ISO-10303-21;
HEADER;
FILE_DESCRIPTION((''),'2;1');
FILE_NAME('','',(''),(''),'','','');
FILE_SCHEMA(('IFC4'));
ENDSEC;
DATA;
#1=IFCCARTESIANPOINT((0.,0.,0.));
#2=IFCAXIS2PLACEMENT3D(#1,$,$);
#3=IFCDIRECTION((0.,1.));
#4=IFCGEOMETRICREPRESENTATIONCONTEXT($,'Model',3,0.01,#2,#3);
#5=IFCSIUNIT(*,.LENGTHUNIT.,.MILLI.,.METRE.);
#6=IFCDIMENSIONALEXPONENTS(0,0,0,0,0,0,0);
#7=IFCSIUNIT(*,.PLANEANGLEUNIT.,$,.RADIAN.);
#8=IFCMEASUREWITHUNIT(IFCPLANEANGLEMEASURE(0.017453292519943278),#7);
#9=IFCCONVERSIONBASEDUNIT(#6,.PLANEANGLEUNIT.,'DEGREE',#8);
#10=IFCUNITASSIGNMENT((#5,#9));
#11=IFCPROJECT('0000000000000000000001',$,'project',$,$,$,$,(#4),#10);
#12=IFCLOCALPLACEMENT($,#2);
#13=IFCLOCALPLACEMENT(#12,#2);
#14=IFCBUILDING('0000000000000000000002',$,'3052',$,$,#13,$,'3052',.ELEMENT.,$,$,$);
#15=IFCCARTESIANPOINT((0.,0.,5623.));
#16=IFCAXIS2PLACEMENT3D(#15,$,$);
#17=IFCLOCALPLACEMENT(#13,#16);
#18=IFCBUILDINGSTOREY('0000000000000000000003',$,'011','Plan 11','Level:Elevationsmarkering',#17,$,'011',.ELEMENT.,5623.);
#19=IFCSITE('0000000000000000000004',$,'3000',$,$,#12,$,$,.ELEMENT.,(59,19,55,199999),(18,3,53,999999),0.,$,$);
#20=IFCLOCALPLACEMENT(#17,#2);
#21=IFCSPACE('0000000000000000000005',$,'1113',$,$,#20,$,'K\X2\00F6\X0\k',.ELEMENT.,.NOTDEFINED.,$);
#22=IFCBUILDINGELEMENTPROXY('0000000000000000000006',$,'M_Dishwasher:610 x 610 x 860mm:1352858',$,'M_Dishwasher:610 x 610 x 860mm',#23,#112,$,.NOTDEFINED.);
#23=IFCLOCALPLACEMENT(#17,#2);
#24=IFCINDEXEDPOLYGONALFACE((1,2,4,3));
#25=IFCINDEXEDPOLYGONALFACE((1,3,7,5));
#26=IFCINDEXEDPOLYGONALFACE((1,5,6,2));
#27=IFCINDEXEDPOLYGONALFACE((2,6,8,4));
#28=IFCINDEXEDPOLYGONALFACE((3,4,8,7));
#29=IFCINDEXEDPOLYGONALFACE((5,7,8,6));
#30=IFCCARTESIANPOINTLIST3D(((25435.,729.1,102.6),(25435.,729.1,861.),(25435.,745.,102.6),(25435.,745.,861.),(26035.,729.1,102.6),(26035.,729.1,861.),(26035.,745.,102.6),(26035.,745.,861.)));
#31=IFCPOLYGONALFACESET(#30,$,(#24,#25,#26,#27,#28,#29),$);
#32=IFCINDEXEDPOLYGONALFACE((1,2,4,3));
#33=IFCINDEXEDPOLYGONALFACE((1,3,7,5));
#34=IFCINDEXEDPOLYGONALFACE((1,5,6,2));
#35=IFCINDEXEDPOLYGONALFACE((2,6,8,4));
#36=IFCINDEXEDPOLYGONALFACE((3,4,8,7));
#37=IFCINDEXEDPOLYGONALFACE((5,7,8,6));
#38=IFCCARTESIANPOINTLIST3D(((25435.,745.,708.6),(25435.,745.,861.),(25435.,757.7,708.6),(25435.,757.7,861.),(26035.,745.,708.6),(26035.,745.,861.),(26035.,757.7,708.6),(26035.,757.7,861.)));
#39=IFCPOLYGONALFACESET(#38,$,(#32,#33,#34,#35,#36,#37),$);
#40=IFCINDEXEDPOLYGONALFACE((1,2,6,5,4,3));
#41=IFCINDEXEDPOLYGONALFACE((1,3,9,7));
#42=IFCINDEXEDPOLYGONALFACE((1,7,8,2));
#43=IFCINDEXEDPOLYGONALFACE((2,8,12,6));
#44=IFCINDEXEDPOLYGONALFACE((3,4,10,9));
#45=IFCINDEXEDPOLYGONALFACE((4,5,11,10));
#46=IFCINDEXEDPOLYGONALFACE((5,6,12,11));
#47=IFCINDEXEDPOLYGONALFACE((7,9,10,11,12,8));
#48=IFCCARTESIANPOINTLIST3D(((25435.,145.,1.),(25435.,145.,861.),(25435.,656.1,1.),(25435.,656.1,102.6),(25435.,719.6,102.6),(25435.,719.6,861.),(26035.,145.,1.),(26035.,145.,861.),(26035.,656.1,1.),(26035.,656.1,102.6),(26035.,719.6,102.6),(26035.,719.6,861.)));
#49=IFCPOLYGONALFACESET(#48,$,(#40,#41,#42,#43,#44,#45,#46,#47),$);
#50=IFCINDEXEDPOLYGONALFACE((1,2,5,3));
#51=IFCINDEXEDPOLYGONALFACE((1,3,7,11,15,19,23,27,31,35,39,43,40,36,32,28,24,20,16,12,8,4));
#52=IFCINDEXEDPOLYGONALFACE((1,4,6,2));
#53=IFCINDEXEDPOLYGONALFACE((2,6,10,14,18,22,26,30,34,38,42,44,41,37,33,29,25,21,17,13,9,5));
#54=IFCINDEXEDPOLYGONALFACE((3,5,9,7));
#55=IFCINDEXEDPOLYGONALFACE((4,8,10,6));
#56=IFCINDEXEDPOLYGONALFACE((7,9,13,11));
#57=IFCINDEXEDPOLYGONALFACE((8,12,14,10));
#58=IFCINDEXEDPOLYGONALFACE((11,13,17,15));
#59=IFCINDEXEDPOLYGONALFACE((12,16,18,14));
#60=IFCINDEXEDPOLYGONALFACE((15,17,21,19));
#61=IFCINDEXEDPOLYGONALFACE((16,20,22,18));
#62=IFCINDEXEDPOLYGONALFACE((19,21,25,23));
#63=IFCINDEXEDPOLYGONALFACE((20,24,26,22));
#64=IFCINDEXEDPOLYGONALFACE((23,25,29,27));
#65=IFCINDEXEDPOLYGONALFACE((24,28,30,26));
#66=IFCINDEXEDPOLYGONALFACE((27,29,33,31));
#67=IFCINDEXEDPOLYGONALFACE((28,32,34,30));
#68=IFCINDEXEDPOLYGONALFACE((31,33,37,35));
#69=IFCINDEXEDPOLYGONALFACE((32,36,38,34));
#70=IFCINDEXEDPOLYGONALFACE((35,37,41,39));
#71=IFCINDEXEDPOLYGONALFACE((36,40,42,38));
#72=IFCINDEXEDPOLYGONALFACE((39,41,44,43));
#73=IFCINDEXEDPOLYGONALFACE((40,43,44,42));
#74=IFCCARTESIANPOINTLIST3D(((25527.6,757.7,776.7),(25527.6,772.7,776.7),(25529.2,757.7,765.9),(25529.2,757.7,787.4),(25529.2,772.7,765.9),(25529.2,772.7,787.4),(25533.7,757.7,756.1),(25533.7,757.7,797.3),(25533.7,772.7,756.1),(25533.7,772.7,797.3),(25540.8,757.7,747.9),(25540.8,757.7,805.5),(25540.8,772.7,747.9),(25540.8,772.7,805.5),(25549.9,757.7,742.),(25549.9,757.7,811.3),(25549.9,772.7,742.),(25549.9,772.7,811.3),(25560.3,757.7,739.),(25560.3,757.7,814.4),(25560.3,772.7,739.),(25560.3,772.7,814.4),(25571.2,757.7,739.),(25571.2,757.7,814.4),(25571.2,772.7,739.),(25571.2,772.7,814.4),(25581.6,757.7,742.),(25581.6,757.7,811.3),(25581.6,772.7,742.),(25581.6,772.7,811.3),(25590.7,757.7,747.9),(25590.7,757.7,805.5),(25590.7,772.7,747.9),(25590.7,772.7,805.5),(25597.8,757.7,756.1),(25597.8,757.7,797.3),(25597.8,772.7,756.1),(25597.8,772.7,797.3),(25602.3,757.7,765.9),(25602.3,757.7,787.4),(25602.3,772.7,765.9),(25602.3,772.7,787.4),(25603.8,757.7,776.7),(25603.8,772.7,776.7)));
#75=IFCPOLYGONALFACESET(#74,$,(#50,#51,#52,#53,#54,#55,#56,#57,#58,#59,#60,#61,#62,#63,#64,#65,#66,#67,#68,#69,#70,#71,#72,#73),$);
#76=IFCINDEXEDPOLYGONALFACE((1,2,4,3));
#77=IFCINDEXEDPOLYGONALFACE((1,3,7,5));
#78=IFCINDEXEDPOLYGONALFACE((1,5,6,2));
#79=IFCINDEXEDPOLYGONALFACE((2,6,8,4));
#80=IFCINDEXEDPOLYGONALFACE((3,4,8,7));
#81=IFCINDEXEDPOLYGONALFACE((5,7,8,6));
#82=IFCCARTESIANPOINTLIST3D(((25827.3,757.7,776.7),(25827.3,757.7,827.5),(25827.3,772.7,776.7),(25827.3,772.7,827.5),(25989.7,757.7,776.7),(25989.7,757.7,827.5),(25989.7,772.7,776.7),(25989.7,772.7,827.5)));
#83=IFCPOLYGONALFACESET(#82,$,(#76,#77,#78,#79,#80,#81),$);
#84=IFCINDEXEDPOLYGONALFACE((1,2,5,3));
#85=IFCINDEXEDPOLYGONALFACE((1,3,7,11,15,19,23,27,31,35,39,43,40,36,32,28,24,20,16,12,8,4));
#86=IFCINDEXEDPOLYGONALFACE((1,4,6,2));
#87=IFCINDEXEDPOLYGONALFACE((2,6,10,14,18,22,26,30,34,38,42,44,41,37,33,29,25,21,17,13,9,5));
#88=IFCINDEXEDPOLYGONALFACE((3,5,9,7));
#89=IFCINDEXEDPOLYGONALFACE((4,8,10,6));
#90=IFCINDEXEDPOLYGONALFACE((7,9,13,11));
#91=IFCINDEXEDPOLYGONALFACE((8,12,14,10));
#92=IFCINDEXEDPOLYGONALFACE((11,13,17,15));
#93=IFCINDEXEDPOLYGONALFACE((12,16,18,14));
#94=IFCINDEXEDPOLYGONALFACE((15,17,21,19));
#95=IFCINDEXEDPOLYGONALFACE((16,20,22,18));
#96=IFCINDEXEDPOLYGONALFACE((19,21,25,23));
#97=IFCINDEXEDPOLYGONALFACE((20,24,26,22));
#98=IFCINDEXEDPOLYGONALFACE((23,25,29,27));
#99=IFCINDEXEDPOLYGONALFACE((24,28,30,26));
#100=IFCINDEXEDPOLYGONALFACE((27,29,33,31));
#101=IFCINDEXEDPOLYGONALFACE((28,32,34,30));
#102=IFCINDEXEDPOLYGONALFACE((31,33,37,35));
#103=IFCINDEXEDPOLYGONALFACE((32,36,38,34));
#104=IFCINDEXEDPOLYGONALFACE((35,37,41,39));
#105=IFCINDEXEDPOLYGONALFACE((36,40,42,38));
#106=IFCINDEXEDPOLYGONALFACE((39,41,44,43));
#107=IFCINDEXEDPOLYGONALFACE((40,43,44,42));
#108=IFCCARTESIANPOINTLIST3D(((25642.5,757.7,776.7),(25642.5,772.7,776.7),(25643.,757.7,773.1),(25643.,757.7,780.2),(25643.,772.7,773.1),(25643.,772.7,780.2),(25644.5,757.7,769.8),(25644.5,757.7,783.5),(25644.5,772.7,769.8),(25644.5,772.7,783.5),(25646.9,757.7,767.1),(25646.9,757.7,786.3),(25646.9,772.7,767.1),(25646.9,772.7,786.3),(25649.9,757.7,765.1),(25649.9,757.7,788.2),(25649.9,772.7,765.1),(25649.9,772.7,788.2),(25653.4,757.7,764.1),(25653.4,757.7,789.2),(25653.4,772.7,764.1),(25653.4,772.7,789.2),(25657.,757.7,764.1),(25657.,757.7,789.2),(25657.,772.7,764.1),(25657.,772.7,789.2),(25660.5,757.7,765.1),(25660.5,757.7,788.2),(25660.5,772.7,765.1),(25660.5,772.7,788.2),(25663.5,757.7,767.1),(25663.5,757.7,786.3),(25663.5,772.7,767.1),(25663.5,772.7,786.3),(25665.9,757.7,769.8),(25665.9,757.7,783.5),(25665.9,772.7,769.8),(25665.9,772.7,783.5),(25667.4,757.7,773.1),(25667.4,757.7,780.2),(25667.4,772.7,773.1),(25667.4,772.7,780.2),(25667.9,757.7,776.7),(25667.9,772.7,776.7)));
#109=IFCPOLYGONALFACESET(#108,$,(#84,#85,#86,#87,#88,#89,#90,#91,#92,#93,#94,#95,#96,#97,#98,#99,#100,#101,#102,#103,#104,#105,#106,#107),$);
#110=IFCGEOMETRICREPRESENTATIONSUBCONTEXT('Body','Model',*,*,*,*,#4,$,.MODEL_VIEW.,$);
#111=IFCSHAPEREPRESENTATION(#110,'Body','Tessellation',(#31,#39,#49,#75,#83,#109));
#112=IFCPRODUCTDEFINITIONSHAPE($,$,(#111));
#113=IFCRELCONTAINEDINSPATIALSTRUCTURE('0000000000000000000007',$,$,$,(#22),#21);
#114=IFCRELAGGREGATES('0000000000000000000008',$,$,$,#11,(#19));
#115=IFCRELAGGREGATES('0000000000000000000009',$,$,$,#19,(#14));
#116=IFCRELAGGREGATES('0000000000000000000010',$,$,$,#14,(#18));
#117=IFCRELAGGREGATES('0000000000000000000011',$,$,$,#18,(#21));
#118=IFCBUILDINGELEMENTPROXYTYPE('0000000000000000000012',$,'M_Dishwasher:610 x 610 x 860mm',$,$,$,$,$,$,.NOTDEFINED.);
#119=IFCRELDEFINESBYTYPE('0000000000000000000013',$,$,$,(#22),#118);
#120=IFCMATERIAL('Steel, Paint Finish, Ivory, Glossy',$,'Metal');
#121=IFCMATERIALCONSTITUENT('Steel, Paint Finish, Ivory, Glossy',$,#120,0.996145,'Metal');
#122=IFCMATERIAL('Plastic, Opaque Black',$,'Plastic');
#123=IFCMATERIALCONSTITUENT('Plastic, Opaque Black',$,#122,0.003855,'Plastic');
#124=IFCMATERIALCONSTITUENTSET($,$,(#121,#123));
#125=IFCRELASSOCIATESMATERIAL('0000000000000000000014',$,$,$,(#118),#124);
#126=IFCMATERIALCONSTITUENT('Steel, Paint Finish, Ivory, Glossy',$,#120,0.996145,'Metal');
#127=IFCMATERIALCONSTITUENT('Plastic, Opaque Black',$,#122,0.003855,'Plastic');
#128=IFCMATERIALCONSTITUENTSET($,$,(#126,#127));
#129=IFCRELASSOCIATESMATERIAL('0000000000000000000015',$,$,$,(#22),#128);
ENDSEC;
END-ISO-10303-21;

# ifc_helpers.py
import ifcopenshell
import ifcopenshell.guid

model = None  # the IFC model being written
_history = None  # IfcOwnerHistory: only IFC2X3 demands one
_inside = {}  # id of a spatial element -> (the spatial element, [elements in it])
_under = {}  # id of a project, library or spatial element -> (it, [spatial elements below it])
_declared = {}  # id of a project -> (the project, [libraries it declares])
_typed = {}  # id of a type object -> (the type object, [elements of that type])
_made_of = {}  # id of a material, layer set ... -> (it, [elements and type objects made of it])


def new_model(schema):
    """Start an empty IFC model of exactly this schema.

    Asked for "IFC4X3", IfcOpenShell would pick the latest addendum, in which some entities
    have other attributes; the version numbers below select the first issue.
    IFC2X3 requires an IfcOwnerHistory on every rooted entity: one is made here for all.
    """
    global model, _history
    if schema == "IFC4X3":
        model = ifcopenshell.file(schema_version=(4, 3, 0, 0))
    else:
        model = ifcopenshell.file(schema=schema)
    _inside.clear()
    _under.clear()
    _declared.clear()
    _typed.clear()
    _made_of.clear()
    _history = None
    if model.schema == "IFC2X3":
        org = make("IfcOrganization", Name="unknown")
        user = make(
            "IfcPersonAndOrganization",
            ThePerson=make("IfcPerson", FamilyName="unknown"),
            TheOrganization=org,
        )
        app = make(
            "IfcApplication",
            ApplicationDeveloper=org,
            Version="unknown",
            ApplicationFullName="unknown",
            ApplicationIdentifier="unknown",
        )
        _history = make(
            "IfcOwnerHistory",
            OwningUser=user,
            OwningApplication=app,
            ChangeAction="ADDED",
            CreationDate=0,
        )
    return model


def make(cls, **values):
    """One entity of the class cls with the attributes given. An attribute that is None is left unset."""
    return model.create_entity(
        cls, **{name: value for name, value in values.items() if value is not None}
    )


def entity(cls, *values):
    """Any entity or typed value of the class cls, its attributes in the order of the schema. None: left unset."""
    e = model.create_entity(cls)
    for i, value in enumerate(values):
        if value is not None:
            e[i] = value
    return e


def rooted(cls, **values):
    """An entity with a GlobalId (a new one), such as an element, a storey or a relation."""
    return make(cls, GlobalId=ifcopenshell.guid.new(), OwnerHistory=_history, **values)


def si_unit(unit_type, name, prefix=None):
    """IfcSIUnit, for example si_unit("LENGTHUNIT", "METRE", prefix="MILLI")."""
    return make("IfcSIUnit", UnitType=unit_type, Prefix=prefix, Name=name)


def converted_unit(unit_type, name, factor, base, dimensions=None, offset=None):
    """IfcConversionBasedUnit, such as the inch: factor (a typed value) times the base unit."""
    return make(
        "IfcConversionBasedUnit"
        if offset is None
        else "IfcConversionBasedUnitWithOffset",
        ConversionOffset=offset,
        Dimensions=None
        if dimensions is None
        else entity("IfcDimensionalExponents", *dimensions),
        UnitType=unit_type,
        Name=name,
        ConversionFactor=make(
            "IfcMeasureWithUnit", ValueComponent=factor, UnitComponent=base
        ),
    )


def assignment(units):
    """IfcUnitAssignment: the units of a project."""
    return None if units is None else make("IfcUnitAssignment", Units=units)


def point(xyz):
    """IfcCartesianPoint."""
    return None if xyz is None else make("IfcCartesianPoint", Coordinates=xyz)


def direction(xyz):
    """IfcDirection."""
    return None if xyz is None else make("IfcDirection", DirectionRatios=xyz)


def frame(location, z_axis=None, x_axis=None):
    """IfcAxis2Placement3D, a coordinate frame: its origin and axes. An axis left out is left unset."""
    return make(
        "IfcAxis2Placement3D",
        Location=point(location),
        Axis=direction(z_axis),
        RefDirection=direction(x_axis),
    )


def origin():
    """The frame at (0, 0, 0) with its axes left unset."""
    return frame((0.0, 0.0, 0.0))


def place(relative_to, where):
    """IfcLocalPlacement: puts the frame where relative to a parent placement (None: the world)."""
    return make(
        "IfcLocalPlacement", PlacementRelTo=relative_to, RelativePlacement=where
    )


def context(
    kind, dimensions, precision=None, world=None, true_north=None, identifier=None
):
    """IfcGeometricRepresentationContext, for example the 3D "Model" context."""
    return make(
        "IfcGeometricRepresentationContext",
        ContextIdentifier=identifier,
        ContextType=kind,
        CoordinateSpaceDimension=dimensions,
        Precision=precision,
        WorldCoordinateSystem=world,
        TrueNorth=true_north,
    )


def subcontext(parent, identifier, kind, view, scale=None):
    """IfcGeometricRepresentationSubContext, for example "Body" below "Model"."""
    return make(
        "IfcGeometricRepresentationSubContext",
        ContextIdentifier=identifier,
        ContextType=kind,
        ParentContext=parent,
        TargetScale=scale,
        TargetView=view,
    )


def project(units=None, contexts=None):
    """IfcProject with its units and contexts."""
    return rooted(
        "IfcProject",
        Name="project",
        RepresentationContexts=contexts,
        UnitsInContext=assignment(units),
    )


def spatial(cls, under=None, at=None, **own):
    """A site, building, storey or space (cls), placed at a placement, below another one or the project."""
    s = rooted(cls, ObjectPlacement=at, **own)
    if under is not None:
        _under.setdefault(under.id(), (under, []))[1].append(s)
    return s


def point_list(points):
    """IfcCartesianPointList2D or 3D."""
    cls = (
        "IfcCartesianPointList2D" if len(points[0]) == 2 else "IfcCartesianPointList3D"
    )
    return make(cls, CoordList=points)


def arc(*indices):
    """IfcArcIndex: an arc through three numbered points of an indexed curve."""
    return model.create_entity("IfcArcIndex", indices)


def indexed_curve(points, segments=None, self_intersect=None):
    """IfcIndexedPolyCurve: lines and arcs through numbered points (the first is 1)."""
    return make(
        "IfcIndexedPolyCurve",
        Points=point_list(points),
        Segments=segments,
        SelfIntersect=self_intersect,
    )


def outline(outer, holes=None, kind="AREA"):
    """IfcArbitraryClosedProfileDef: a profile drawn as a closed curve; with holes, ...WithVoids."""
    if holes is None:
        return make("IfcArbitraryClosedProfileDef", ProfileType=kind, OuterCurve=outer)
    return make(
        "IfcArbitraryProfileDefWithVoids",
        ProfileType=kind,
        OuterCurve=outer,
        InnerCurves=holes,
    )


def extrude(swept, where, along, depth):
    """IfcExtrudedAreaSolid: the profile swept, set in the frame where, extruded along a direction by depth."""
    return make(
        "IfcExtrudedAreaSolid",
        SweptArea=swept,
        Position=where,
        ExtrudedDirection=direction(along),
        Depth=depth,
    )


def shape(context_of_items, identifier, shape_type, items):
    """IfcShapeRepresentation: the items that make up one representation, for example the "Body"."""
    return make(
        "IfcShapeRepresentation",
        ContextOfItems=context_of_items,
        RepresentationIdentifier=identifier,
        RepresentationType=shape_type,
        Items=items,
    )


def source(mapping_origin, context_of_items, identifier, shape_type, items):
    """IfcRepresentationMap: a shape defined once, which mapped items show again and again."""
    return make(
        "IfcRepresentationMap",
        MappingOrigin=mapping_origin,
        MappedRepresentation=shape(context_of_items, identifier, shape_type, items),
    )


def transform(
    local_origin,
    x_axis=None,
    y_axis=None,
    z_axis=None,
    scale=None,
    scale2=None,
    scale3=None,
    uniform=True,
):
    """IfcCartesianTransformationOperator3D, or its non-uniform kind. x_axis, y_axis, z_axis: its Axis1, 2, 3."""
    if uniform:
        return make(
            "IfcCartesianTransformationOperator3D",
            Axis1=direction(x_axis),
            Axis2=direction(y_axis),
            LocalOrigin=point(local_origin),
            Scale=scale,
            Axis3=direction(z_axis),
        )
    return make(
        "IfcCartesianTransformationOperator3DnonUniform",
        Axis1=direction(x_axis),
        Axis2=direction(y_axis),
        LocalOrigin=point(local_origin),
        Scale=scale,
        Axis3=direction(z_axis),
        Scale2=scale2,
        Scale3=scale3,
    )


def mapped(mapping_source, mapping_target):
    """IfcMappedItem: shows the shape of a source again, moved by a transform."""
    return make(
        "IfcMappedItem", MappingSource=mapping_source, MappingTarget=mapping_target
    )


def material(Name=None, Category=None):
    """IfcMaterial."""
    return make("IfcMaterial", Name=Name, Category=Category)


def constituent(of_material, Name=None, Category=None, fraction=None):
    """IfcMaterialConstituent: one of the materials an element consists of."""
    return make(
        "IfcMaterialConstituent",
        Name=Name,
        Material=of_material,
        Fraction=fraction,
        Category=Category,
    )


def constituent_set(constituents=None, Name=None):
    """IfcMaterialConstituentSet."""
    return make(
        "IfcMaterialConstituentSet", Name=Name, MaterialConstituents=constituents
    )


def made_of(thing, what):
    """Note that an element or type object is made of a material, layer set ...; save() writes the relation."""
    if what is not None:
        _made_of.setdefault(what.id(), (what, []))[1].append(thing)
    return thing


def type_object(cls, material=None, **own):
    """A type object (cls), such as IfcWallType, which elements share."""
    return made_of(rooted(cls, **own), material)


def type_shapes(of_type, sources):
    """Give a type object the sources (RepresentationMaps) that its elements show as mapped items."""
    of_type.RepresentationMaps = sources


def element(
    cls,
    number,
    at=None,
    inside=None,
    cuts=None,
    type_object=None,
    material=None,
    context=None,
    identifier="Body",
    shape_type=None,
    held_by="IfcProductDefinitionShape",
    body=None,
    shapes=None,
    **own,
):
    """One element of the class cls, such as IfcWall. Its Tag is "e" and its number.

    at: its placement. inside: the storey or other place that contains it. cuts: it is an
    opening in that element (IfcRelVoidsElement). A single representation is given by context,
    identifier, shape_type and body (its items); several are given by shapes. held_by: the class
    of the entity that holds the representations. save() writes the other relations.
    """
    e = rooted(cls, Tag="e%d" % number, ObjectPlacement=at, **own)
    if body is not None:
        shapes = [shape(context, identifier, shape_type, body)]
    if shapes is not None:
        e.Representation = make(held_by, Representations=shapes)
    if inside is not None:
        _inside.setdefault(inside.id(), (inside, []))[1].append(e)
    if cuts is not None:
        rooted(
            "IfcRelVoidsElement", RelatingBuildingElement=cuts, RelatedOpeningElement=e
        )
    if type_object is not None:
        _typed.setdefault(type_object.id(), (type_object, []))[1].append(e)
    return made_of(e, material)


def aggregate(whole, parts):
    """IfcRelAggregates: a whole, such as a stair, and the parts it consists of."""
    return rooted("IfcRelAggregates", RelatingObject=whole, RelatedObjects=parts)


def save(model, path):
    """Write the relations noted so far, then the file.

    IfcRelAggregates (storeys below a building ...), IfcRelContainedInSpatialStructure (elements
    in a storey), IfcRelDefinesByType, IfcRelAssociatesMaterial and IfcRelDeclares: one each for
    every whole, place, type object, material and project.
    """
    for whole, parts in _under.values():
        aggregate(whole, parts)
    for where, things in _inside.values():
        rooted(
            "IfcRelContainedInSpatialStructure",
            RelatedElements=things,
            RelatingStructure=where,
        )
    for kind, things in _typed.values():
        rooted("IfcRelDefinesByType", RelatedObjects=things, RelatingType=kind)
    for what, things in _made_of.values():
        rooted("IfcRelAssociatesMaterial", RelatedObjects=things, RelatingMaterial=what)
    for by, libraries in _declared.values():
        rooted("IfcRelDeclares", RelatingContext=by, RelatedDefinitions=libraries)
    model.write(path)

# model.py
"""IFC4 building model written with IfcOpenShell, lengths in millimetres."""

from ifc_helpers import new_model, entity, si_unit, converted_unit, direction, frame, origin, place, context, subcontext, project, spatial, arc, indexed_curve, outline, extrude, source, transform, mapped, material, constituent, constituent_set, type_object, type_shapes, element, save


model = new_model("IFC4")

# Units and contexts
model_context = context("Model", 3, precision=0.01, world=origin(), true_north=direction((0.0, 1.0)))
body_context = subcontext(model_context, "Body", "Model", "MODEL_VIEW")
ifc_project = project(units=[si_unit("LENGTHUNIT", "METRE", prefix="MILLI"), converted_unit("PLANEANGLEUNIT", "DEGREE", entity("IfcPlaneAngleMeasure", 0.017453292519943278), si_unit("PLANEANGLEUNIT", "RADIAN"), dimensions=[0, 0, 0, 0, 0, 0, 0])], contexts=[model_context])

# Site, building, storey
site_placement = place(None, origin())
site = spatial("IfcSite", under=ifc_project, at=site_placement, Name="3000", CompositionType="ELEMENT", RefLatitude=(59, 19, 55, 199999), RefLongitude=(18, 3, 53, 999999), RefElevation=0.0)
building_placement = place(site_placement, origin())
building = spatial("IfcBuilding", under=site, at=building_placement, Name="3052", LongName="3052", CompositionType="ELEMENT")
storey_placement = place(building_placement, frame((0.0, 0.0, 5623.0)))
storey = spatial("IfcBuildingStorey", under=building, at=storey_placement, Name="011", Description="Plan 11", ObjectType="Level:Elevationsmarkering", LongName="011", CompositionType="ELEMENT", Elevation=5623.0)

# Shared definitions
space_placement = place(storey_placement, origin())
space = spatial("IfcSpace", under=storey, at=space_placement, Name="1113", LongName="Kök", CompositionType="ELEMENT", PredefinedType="NOTDEFINED")

# Building element proxy
ifc_material_1 = material(Name="Steel, Paint Finish, Ivory, Glossy", Category="Metal")
ifc_constituent_1 = constituent(ifc_material_1, Name="Steel, Paint Finish, Ivory, Glossy", Category="Metal", fraction=0.996145)
ifc_material_2 = material(Name="Plastic, Opaque Black", Category="Plastic")
ifc_constituent_2 = constituent(ifc_material_2, Name="Plastic, Opaque Black", Category="Plastic", fraction=0.003855)
ifc_constituent_set_1 = constituent_set(constituents=[ifc_constituent_1, ifc_constituent_2])
ifc_constituent_3 = constituent(ifc_material_1, Name="Steel, Paint Finish, Ivory, Glossy", Category="Metal", fraction=0.996145)
ifc_constituent_4 = constituent(ifc_material_2, Name="Plastic, Opaque Black", Category="Plastic", fraction=0.003855)
ifc_constituent_set_2 = constituent_set(constituents=[ifc_constituent_3, ifc_constituent_4])
building_element_proxy_type = type_object("IfcBuildingElementProxyType", Name="M_Dishwasher:610 x 610 x 860mm", PredefinedType="NOTDEFINED", material=ifc_constituent_set_2)
shared_shape_1 = source(origin(), body_context, "Body", "SweptSolid", [
    extrude(outline(indexed_curve([(-7.9, -300.0), (7.9, -300.0), (7.9, 300.0), (-7.9, 300.0), (-7.9, -300.0)], self_intersect=False)), frame((377.5, -30.4, 101.6), z_axis=(0.0, 0.0, 1.0), x_axis=(0.0, 1.0, 0.0)), (0.0, 0.0, 1.0), 758.4),
    extrude(outline(indexed_curve([(-300.0, -6.4), (300.0, -6.4), (300.0, 6.4), (-300.0, 6.4), (-300.0, -6.4)], self_intersect=False)), frame((377.5, -44.7, 707.6), z_axis=(0.0, 0.0, 1.0), x_axis=(-1.0, 0.0, 0.0)), (0.0, 0.0, 1.0), 152.4),
    extrude(outline(indexed_curve([(-320.5, -361.9), (539.5, -361.9), (539.5, 212.7), (-218.9, 212.7), (-218.9, 149.2), (-320.5, 149.2), (-320.5, -361.9)], self_intersect=False)), frame((77.5, 199.7, 320.5), z_axis=(1.0, 0.0, 0.0), x_axis=(0.0, 0.0, 1.0)), (0.0, 0.0, 1.0), 600.0),
    extrude(outline(indexed_curve([(-38.1, 0.0), (0.0, -38.1), (38.1, 0.0), (0.0, 38.1)], segments=[arc(1, 2, 3), arc(3, 4, 1)], self_intersect=False)), frame((546.8, -66.1, 775.7), z_axis=(0.0, 1.0, 0.0), x_axis=(-1.0, 0.0, 0.0)), (0.0, 0.0, 1.0), 15.0),
    extrude(outline(indexed_curve([(-7.5, -81.2), (7.5, -81.2), (7.5, 81.2), (-7.5, 81.2), (-7.5, -81.2)], self_intersect=False)), frame((204.0, -58.6, 775.7), z_axis=(0.0, 0.0, 1.0), x_axis=(0.0, 1.0, 0.0)), (0.0, 0.0, 1.0), 50.8),
    extrude(outline(indexed_curve([(-12.7, 0.0), (0.0, -12.7), (12.7, 0.0), (0.0, 12.7)], segments=[arc(1, 2, 3), arc(3, 4, 1)], self_intersect=False)), frame((457.3, -66.1, 775.7), z_axis=(0.0, 1.0, 0.0), x_axis=(-1.0, 0.0, 0.0)), (0.0, 0.0, 1.0), 15.0),
])
type_shapes(building_element_proxy_type, [shared_shape_1])
proxy_placement = place(space_placement, frame((26112.5, 706.6, 1.0), z_axis=(0.0, 0.0, 1.0), x_axis=(-1.0, 0.0, 0.0)))
element("IfcBuildingElementProxy", 1, at=proxy_placement, inside=space, type_object=building_element_proxy_type, material=ifc_constituent_set_1, Name="M_Dishwasher:610 x 610 x 860mm:1352858", ObjectType="M_Dishwasher:610 x 610 x 860mm", PredefinedType="NOTDEFINED", context=body_context, shape_type="MappedRepresentation", body=[
    mapped(shared_shape_1, transform((0.0, 0.0, 0.0), scale=1.0)),
])

save(model, "model.ifc")
